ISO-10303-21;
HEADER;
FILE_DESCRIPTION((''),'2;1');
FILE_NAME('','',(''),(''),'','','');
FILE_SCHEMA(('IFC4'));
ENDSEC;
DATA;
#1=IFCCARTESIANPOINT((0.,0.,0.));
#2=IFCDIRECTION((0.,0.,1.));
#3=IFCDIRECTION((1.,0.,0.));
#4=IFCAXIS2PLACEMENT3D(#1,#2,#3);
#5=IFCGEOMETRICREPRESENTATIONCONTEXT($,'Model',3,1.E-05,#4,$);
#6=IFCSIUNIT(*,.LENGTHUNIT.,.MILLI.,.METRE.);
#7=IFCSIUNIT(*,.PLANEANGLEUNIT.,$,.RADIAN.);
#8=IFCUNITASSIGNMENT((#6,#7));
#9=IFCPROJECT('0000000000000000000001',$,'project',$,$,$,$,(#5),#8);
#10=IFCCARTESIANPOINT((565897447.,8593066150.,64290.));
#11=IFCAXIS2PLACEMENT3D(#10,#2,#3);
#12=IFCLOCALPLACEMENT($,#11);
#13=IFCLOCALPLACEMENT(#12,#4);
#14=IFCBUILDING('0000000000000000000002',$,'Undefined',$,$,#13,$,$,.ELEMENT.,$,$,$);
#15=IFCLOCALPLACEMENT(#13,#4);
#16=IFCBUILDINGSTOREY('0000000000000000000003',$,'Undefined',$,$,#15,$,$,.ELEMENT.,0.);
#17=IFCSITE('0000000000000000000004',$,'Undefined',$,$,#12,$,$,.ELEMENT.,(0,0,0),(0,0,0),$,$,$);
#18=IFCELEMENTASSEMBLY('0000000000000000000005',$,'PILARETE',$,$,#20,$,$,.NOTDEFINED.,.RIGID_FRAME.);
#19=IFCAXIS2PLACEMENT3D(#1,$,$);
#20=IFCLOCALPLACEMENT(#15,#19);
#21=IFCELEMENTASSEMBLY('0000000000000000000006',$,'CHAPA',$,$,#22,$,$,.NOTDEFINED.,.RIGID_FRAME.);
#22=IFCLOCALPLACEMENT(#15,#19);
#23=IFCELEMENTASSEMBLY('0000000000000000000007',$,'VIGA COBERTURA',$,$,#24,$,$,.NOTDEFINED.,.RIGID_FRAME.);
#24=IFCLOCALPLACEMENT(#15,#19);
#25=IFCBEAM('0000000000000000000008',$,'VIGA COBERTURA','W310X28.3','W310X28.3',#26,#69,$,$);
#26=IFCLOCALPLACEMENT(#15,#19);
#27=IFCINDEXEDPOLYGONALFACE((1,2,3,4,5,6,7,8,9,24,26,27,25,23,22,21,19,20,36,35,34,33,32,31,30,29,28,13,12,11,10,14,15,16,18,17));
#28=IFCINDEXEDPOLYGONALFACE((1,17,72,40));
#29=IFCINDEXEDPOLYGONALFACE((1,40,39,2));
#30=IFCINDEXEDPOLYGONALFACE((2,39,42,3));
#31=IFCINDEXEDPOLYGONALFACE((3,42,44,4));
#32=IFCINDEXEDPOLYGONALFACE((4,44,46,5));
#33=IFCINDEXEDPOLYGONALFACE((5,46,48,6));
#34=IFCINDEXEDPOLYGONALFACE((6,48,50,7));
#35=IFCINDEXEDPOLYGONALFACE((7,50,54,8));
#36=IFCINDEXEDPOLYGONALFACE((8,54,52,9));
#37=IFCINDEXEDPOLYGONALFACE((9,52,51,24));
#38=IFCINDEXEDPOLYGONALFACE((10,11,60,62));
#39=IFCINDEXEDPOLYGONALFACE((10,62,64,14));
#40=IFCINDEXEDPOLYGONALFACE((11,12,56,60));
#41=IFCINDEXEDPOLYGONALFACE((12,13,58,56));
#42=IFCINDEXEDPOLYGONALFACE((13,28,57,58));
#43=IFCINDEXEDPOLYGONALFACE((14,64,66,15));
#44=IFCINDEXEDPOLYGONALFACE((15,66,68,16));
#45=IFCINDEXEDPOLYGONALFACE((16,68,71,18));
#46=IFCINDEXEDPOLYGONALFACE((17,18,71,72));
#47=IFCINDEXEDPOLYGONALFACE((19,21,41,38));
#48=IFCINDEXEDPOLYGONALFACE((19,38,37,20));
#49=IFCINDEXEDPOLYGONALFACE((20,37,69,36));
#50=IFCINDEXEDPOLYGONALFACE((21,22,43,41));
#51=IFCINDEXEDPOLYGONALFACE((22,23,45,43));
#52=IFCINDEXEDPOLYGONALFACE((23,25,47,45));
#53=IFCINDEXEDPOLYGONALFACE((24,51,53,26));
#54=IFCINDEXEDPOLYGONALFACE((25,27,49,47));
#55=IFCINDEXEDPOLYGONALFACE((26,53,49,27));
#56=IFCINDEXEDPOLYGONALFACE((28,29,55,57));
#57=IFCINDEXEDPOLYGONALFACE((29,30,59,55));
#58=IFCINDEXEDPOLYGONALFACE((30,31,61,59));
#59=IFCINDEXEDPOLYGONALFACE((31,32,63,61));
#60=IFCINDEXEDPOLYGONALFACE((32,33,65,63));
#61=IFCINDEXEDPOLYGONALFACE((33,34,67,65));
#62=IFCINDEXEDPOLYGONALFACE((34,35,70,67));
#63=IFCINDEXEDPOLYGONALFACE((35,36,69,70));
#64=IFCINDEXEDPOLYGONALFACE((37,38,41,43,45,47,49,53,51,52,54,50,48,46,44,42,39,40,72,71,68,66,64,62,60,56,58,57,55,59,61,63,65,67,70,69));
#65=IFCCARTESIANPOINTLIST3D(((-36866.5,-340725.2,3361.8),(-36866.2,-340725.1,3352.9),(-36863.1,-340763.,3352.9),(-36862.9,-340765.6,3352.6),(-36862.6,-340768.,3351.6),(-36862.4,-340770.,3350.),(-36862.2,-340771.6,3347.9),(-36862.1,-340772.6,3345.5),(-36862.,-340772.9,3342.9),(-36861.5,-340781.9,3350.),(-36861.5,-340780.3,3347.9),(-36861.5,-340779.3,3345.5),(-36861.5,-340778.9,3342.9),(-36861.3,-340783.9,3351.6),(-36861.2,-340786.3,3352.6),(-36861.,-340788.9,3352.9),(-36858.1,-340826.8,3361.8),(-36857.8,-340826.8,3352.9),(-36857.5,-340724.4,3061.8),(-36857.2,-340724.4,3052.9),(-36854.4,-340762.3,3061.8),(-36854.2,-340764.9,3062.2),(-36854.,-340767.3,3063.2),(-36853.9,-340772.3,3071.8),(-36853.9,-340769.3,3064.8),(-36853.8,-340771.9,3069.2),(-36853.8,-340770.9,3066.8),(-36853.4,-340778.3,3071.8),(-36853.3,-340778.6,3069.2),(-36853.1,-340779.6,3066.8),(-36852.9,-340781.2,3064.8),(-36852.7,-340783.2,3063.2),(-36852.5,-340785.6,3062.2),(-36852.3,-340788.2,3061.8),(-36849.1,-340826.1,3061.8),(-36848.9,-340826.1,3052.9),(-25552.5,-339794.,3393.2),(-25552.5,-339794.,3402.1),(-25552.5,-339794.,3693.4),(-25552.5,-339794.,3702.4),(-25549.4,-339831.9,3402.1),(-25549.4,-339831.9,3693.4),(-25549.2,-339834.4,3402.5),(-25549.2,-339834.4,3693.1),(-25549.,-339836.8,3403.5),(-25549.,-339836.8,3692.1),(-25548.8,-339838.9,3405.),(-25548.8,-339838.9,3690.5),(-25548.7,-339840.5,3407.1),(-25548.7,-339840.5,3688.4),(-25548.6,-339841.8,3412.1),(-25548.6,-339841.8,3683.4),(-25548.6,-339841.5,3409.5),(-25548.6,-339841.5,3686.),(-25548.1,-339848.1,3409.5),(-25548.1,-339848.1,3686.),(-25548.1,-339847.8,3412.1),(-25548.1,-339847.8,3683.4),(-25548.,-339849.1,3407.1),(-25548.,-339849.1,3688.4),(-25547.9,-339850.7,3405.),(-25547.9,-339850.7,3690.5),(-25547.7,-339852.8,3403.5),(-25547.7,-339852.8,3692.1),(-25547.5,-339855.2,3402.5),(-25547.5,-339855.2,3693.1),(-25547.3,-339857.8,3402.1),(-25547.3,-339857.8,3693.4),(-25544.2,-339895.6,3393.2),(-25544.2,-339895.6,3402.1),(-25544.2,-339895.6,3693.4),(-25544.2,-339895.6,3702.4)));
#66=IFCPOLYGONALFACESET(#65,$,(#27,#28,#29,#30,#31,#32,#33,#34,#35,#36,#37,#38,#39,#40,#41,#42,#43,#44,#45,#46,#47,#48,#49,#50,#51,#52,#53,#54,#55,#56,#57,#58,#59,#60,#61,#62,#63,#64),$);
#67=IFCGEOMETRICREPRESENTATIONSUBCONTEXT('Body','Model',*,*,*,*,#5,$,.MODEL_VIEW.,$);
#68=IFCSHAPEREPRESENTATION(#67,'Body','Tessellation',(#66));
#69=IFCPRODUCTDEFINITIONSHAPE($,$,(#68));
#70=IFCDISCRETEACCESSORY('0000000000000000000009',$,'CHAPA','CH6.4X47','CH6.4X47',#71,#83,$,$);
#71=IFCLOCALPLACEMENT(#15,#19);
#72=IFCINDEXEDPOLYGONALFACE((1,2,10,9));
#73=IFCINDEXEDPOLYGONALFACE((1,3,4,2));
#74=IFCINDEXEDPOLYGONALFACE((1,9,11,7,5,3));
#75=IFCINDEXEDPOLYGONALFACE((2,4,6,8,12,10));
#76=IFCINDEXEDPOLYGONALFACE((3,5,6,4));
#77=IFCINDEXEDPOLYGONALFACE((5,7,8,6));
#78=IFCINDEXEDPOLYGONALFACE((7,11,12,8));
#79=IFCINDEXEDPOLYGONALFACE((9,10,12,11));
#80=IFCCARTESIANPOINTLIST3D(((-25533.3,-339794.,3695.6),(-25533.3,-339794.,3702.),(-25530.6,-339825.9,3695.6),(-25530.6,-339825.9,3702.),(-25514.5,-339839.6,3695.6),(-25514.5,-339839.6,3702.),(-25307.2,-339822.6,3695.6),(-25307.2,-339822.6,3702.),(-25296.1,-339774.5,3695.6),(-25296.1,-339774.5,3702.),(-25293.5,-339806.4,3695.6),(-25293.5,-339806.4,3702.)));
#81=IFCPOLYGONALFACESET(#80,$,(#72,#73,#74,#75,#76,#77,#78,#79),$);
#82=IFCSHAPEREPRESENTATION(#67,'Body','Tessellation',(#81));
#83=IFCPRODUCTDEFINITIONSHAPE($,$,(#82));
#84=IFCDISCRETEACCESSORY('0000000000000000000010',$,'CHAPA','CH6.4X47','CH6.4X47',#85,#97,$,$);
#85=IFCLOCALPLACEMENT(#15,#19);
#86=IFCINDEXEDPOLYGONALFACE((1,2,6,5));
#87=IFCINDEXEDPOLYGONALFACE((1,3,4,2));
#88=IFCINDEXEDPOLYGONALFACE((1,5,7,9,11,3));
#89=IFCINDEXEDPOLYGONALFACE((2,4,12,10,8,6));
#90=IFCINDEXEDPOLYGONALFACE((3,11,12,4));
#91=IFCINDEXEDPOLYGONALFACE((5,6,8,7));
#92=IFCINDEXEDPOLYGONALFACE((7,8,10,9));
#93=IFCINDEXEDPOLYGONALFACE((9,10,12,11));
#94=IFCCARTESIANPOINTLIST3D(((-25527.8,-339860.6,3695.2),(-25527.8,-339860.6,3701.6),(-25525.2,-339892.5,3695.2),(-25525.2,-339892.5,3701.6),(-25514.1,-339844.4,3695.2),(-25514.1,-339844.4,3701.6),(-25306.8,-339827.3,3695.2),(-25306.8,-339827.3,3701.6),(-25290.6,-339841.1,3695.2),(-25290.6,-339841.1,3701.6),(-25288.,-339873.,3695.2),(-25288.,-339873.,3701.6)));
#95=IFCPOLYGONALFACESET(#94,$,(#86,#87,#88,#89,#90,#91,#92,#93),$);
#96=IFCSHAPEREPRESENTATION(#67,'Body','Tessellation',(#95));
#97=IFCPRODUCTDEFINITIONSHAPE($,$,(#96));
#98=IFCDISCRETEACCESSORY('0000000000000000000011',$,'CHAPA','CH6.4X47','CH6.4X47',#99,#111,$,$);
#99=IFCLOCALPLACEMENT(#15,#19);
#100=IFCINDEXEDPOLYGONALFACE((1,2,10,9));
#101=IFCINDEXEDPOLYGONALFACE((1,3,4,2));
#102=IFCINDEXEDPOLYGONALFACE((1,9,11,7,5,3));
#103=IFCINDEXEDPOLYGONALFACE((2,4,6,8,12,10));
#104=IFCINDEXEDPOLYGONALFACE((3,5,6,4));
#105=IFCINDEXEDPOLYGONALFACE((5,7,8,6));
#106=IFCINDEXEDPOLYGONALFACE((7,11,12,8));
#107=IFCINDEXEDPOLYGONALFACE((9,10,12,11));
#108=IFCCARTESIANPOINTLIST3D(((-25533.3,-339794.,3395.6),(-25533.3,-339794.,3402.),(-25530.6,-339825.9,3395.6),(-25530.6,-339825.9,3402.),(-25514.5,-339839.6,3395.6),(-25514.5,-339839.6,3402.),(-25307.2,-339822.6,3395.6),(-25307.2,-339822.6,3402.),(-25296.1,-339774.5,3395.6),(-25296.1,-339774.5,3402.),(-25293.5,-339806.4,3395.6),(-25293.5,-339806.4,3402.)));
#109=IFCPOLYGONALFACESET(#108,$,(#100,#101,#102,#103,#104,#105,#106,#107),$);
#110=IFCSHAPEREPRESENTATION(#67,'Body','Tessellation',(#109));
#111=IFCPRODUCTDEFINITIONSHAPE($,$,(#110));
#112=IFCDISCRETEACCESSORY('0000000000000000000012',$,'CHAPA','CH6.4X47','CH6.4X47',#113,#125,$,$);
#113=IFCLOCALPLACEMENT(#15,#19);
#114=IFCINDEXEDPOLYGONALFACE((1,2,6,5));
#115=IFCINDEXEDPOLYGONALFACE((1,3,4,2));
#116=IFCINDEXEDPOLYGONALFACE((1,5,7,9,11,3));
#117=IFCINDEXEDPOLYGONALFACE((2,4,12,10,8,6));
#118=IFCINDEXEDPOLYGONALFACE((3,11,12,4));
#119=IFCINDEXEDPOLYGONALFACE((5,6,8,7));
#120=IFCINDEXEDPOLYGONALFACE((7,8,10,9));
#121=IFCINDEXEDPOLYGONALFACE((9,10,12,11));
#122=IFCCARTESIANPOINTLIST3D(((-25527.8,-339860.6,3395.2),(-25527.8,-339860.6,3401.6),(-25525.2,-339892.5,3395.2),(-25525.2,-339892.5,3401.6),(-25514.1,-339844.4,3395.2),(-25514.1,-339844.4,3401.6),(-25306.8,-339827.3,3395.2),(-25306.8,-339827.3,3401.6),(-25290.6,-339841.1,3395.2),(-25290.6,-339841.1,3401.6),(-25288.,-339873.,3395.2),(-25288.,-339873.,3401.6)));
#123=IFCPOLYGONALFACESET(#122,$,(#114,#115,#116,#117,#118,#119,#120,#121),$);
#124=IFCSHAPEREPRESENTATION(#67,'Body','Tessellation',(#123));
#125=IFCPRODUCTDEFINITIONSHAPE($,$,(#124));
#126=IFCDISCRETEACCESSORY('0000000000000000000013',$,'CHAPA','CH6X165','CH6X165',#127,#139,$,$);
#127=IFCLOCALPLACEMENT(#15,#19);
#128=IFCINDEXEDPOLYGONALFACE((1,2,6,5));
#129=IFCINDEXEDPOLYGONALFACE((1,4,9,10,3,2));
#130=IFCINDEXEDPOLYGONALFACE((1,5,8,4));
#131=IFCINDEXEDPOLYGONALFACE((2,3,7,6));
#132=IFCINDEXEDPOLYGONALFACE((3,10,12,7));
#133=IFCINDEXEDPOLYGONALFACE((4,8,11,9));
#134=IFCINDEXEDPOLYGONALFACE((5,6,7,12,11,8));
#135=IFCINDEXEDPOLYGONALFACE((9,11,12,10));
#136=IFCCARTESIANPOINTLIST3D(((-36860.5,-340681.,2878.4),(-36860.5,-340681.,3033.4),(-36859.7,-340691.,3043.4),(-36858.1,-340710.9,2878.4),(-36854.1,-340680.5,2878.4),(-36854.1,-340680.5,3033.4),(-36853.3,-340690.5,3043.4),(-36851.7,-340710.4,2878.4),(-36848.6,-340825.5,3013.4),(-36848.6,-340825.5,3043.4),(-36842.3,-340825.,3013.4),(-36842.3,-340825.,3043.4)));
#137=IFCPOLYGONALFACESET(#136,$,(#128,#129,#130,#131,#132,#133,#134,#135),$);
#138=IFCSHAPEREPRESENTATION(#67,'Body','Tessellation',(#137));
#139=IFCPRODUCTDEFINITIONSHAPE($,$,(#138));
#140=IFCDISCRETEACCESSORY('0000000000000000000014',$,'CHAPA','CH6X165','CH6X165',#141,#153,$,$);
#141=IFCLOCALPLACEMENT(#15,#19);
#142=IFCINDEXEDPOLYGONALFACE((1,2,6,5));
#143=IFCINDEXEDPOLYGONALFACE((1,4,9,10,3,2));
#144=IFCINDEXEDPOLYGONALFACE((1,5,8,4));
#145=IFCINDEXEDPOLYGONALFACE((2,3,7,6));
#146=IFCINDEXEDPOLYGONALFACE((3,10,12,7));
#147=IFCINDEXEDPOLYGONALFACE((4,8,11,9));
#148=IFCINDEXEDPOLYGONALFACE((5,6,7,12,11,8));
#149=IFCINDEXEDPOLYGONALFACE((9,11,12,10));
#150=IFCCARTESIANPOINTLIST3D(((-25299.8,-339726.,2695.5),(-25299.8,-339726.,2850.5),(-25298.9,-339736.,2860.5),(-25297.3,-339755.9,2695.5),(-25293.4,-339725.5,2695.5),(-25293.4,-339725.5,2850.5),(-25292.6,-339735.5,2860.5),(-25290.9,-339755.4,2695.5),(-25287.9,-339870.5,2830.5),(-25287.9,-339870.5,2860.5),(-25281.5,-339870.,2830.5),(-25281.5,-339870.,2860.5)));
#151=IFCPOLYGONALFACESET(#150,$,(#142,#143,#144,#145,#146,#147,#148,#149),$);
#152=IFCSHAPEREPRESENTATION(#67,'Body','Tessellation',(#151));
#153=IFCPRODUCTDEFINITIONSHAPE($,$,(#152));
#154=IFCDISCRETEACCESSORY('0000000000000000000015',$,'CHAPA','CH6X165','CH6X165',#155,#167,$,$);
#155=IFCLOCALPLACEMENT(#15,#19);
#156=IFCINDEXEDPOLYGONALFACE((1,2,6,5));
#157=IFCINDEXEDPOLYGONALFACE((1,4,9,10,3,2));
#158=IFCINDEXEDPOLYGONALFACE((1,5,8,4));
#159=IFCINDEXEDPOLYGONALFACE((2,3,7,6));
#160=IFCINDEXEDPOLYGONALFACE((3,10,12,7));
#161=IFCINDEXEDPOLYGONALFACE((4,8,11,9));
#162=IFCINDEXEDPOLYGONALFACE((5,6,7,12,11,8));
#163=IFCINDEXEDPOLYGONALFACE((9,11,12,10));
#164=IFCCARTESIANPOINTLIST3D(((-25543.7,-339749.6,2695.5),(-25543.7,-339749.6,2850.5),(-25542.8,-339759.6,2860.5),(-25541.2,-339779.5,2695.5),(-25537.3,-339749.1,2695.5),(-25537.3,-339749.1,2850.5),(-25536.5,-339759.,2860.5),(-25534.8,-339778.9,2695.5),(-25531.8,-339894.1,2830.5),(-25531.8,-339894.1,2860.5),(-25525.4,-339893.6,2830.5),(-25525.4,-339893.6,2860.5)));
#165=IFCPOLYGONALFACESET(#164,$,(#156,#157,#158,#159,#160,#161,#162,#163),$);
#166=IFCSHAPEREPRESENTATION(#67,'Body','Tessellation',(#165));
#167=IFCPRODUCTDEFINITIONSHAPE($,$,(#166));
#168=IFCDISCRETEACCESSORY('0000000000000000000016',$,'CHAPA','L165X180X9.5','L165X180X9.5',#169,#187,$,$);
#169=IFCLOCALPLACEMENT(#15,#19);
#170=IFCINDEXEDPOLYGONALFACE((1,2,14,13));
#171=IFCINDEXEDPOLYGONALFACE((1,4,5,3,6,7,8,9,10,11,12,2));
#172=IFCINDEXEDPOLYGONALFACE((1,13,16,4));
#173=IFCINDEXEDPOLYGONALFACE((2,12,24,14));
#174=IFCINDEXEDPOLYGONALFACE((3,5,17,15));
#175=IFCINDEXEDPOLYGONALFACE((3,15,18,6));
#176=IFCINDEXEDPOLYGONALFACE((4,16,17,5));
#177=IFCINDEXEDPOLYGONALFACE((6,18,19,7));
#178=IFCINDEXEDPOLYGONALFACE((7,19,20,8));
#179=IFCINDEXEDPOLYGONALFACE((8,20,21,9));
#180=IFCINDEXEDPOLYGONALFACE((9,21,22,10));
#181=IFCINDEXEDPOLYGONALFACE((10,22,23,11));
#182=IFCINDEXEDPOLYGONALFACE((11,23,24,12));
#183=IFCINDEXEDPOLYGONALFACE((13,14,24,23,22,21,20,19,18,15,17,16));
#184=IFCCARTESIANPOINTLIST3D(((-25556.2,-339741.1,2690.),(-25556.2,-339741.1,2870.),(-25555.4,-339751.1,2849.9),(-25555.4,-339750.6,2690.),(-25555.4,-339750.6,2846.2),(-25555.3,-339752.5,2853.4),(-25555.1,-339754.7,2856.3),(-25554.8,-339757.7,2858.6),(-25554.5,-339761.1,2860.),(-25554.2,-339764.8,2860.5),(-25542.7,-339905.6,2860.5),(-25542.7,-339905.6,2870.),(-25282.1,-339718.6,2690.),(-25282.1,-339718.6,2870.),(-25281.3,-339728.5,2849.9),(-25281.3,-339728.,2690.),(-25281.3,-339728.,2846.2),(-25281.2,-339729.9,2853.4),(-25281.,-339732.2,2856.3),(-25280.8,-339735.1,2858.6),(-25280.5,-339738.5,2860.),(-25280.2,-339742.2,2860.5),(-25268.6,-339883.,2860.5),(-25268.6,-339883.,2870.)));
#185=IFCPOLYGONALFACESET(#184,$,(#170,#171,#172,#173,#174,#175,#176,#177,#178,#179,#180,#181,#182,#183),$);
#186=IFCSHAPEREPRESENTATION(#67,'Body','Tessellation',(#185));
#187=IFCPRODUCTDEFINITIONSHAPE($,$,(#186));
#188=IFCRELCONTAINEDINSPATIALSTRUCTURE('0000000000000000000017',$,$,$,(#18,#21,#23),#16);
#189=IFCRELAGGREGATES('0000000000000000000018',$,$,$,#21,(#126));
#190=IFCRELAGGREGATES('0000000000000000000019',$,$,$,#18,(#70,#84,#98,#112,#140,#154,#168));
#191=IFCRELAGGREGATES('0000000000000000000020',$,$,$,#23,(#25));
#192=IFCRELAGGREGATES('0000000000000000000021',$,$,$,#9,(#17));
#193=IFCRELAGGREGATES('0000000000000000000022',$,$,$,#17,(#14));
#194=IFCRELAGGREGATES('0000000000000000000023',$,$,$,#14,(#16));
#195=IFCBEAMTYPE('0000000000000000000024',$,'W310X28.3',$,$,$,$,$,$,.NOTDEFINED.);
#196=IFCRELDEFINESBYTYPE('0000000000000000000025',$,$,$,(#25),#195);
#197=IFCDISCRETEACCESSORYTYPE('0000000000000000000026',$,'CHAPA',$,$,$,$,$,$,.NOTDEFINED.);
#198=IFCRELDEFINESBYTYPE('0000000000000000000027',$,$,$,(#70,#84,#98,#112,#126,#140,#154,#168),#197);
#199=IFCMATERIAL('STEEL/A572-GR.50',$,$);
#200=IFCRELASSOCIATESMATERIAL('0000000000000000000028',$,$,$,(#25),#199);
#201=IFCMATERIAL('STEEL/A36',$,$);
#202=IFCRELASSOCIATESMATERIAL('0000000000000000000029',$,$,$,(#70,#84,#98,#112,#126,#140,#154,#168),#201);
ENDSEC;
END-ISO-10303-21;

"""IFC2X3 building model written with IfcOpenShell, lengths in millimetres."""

from ifc_helpers import new_model, si_unit, frame, origin_with_axes, origin_2d_with_axis, place, context, subcontext, project, spatial, polyline, i_section, l_section, outline, extrude, clip, halfspace, material, type_object, element, aggregate, save


model = new_model("IFC2X3")

# Units and contexts
model_context = context("Model", 3, precision=1e-05, world=origin_with_axes())
body_context = subcontext(model_context, "Body", "Model", "MODEL_VIEW")
ifc_project = project(units=[si_unit("LENGTHUNIT", "METRE", prefix="MILLI"), si_unit("PLANEANGLEUNIT", "RADIAN")], contexts=[model_context])

# Site, building, storey
site_placement = place(None, frame((565897447.0, 8593066150.0, 64290.0), z_axis=(0.0, 0.0, 1.0), x_axis=(1.0, 0.0, 0.0)))
site = spatial("IfcSite", under=ifc_project, at=site_placement, Name="Undefined", CompositionType="ELEMENT", RefLatitude=(0, 0, 0), RefLongitude=(0, 0, 0))
building_placement = place(site_placement, origin_with_axes())
building = spatial("IfcBuilding", under=site, at=building_placement, Name="Undefined", CompositionType="ELEMENT")
storey_placement = place(building_placement, origin_with_axes())
storey = spatial("IfcBuildingStorey", under=building, at=storey_placement, Name="Undefined", CompositionType="ELEMENT", Elevation=0.0)

# Element assembly
assembly_1_placement = place(storey_placement, origin_with_axes())
assembly_1 = element("IfcElementAssembly", 1, at=assembly_1_placement, inside=storey, Name="PILARETE", AssemblyPlace="NOTDEFINED", PredefinedType="RIGID_FRAME")
ifc_material_1 = material(Name="STEEL/A572-GR.50")

# Element assemblies, beam
ifc_material_2 = material(Name="STEEL/A36")
assembly_2_placement = place(storey_placement, origin_with_axes())
assembly_2 = element("IfcElementAssembly", 2, at=assembly_2_placement, inside=storey, Name="CHAPA", AssemblyPlace="NOTDEFINED", PredefinedType="RIGID_FRAME")
assembly_3_placement = place(storey_placement, origin_with_axes())
assembly_3 = element("IfcElementAssembly", 3, at=assembly_3_placement, inside=storey, Name="VIGA COBERTURA", AssemblyPlace="NOTDEFINED", PredefinedType="RIGID_FRAME")
beam_type_1 = type_object("IfcBeamType", Name="W310X28.3", PredefinedType="NOTDEFINED")
beam_1_placement = place(assembly_3_placement, frame((-25531.1, -339843.4, 3548.3), z_axis=(0.029885, 0.00246, -0.99955), x_axis=(-0.996182, -0.081989, -0.029987)))
beam_1 = element("IfcBeam", 4, at=beam_1_placement, type_object=beam_type_1, material=ifc_material_1, Name="VIGA COBERTURA", Description="W310X28.3", ObjectType="W310X28.3", context=body_context, shape_type="Clipping", body=[
    clip(extrude(i_section(OverallWidth=102.0, OverallDepth=309.0, WebThickness=6.0, FlangeThickness=8.9, FilletRadius=10.0, at=origin_2d_with_axis()), frame((11370.0, 0.0, 0.0), z_axis=(-1.0, 0.0, 0.0), x_axis=(0.0, -1.0, 0.0)), (0.0, 0.0, 1.0), 11370.0), halfspace(frame((12.7, 51.0, -154.5), z_axis=(-0.99955, 0.0, 0.029987), x_axis=(0.029987, 0.0, 0.99955)), False)),
])

# Discrete accessories
discrete_accessory_type_1 = type_object("IfcDiscreteAccessoryType", Name="CHAPA")
discrete_accessory_1_placement = place(assembly_1_placement, frame((-25529.4, -339840.8, 3698.8), z_axis=(0.0, 0.0, -1.0), x_axis=(-0.082025, 0.99663, 0.0)))
discrete_accessory_1 = element("IfcDiscreteAccessory", 5, at=discrete_accessory_1_placement, type_object=discrete_accessory_type_1, material=ifc_material_2, Name="CHAPA", Description="CH6.4X47", ObjectType="CH6.4X47", context=body_context, shape_type="SweptSolid", body=[
    extrude(outline(polyline([(0.0, 15.0), (15.0, 0.0), (47.0, 0.0), (47.0, 238.0), (15.0, 238.0), (0.0, 223.0), (0.0, 15.0)])), frame((0.0, 0.0, -3.2), z_axis=(0.0, 0.0, 1.0), x_axis=(1.0, 0.0, 0.0)), (0.0, 0.0, 1.0), 6.4),
])
discrete_accessory_2_placement = place(assembly_1_placement, frame((-25529.0, -339845.6, 3698.4), z_axis=(0.0, 0.0, 1.0), x_axis=(0.082025, -0.99663, 0.0)))
discrete_accessory_2 = element("IfcDiscreteAccessory", 6, at=discrete_accessory_2_placement, type_object=discrete_accessory_type_1, material=ifc_material_2, Name="CHAPA", Description="CH6.4X47", ObjectType="CH6.4X47", context=body_context, shape_type="SweptSolid", body=[
    extrude(outline(polyline([(0.0, 15.0), (15.0, 0.0), (47.0, 0.0), (47.0, 238.0), (15.0, 238.0), (0.0, 223.0), (0.0, 15.0)])), frame((0.0, 0.0, -3.2), z_axis=(0.0, 0.0, 1.0), x_axis=(1.0, 0.0, 0.0)), (0.0, 0.0, 1.0), 6.4),
])
discrete_accessory_3_placement = place(assembly_1_placement, frame((-25529.4, -339840.8, 3398.8), z_axis=(0.0, 0.0, -1.0), x_axis=(-0.082025, 0.99663, 0.0)))
discrete_accessory_3 = element("IfcDiscreteAccessory", 7, at=discrete_accessory_3_placement, type_object=discrete_accessory_type_1, material=ifc_material_2, Name="CHAPA", Description="CH6.4X47", ObjectType="CH6.4X47", context=body_context, shape_type="SweptSolid", body=[
    extrude(outline(polyline([(0.0, 15.0), (15.0, 0.0), (47.0, 0.0), (47.0, 238.0), (15.0, 238.0), (0.0, 223.0), (0.0, 15.0)])), frame((0.0, 0.0, -3.2), z_axis=(0.0, 0.0, 1.0), x_axis=(1.0, 0.0, 0.0)), (0.0, 0.0, 1.0), 6.4),
])
discrete_accessory_4_placement = place(assembly_1_placement, frame((-25529.0, -339845.6, 3398.4), z_axis=(0.0, 0.0, 1.0), x_axis=(0.082025, -0.99663, 0.0)))
discrete_accessory_4 = element("IfcDiscreteAccessory", 8, at=discrete_accessory_4_placement, type_object=discrete_accessory_type_1, material=ifc_material_2, Name="CHAPA", Description="CH6.4X47", ObjectType="CH6.4X47", context=body_context, shape_type="SweptSolid", body=[
    extrude(outline(polyline([(0.0, 15.0), (15.0, 0.0), (47.0, 0.0), (47.0, 238.0), (15.0, 238.0), (0.0, 223.0), (0.0, 15.0)])), frame((0.0, 0.0, -3.2), z_axis=(0.0, 0.0, 1.0), x_axis=(1.0, 0.0, 0.0)), (0.0, 0.0, 1.0), 6.4),
])
discrete_accessory_5_placement = place(assembly_2_placement, frame((-36857.3, -340680.8, 3043.4), z_axis=(-0.99663, -0.082025, 0.000004), x_axis=(-0.000004, 0.0, -1.0)))
discrete_accessory_5 = element("IfcDiscreteAccessory", 9, at=discrete_accessory_5_placement, type_object=discrete_accessory_type_1, material=ifc_material_2, Name="CHAPA", Description="CH6X165", ObjectType="CH6X165", context=body_context, shape_type="SweptSolid", body=[
    extrude(outline(polyline([(0.0, 10.0), (10.0, 0.0), (165.0, 0.0), (165.0, 30.0), (30.0, 145.0), (0.0, 145.0), (0.0, 10.0)])), frame((0.0, 0.0, -3.2), z_axis=(0.0, 0.0, 1.0), x_axis=(1.0, 0.0, 0.0)), (0.0, 0.0, 1.0), 6.4),
])
aggregate(assembly_2, [discrete_accessory_5])
discrete_accessory_6_placement = place(assembly_1_placement, frame((-25296.6, -339725.8, 2860.5), z_axis=(-0.99663, -0.082025, -0.000004), x_axis=(0.000004, 0.0, -1.0)))
discrete_accessory_6 = element("IfcDiscreteAccessory", 10, at=discrete_accessory_6_placement, type_object=discrete_accessory_type_1, material=ifc_material_2, Name="CHAPA", Description="CH6X165", ObjectType="CH6X165", context=body_context, shape_type="SweptSolid", body=[
    extrude(outline(polyline([(0.0, 10.0), (10.0, 0.0), (165.0, 0.0), (165.0, 30.0), (30.0, 145.0), (0.0, 145.0), (0.0, 10.0)])), frame((0.0, 0.0, -3.2), z_axis=(0.0, 0.0, 1.0), x_axis=(1.0, 0.0, 0.0)), (0.0, 0.0, 1.0), 6.4),
])
discrete_accessory_7_placement = place(assembly_1_placement, frame((-25540.5, -339749.3, 2860.5), z_axis=(-0.99663, -0.082025, 0.000004), x_axis=(-0.000004, 0.0, -1.0)))
discrete_accessory_7 = element("IfcDiscreteAccessory", 11, at=discrete_accessory_7_placement, type_object=discrete_accessory_type_1, material=ifc_material_2, Name="CHAPA", Description="CH6X165", ObjectType="CH6X165", context=body_context, shape_type="SweptSolid", body=[
    extrude(outline(polyline([(0.0, 10.0), (10.0, 0.0), (165.0, 0.0), (165.0, 30.0), (30.0, 145.0), (0.0, 145.0), (0.0, 10.0)])), frame((0.0, 0.0, -3.2), z_axis=(0.0, 0.0, 1.0), x_axis=(1.0, 0.0, 0.0)), (0.0, 0.0, 1.0), 6.4),
])
discrete_accessory_8_placement = place(assembly_1_placement, frame((-25549.4, -339823.3, 2780.0), z_axis=(0.082025, -0.99663, 0.0), x_axis=(0.99663, 0.082025, 0.0)))
discrete_accessory_8 = element("IfcDiscreteAccessory", 12, at=discrete_accessory_8_placement, type_object=discrete_accessory_type_1, material=ifc_material_2, Name="CHAPA", Description="L165X180X9.5", ObjectType="L165X180X9.5", context=body_context, shape_type="SweptSolid", body=[
    extrude(l_section(Depth=165.0, Width=180.0, Thickness=9.5, FilletRadius=14.2, at=origin_2d_with_axis()), frame((275.0, 0.0, 0.0), z_axis=(-1.0, 0.0, 0.0), x_axis=(0.0, -1.0, 0.0)), (0.0, 0.0, 1.0), 275.0),
])
aggregate(assembly_1, [discrete_accessory_1, discrete_accessory_2, discrete_accessory_3, discrete_accessory_4, discrete_accessory_6, discrete_accessory_7, discrete_accessory_8])
aggregate(assembly_3, [beam_1])

save(model, "model.ifc")
